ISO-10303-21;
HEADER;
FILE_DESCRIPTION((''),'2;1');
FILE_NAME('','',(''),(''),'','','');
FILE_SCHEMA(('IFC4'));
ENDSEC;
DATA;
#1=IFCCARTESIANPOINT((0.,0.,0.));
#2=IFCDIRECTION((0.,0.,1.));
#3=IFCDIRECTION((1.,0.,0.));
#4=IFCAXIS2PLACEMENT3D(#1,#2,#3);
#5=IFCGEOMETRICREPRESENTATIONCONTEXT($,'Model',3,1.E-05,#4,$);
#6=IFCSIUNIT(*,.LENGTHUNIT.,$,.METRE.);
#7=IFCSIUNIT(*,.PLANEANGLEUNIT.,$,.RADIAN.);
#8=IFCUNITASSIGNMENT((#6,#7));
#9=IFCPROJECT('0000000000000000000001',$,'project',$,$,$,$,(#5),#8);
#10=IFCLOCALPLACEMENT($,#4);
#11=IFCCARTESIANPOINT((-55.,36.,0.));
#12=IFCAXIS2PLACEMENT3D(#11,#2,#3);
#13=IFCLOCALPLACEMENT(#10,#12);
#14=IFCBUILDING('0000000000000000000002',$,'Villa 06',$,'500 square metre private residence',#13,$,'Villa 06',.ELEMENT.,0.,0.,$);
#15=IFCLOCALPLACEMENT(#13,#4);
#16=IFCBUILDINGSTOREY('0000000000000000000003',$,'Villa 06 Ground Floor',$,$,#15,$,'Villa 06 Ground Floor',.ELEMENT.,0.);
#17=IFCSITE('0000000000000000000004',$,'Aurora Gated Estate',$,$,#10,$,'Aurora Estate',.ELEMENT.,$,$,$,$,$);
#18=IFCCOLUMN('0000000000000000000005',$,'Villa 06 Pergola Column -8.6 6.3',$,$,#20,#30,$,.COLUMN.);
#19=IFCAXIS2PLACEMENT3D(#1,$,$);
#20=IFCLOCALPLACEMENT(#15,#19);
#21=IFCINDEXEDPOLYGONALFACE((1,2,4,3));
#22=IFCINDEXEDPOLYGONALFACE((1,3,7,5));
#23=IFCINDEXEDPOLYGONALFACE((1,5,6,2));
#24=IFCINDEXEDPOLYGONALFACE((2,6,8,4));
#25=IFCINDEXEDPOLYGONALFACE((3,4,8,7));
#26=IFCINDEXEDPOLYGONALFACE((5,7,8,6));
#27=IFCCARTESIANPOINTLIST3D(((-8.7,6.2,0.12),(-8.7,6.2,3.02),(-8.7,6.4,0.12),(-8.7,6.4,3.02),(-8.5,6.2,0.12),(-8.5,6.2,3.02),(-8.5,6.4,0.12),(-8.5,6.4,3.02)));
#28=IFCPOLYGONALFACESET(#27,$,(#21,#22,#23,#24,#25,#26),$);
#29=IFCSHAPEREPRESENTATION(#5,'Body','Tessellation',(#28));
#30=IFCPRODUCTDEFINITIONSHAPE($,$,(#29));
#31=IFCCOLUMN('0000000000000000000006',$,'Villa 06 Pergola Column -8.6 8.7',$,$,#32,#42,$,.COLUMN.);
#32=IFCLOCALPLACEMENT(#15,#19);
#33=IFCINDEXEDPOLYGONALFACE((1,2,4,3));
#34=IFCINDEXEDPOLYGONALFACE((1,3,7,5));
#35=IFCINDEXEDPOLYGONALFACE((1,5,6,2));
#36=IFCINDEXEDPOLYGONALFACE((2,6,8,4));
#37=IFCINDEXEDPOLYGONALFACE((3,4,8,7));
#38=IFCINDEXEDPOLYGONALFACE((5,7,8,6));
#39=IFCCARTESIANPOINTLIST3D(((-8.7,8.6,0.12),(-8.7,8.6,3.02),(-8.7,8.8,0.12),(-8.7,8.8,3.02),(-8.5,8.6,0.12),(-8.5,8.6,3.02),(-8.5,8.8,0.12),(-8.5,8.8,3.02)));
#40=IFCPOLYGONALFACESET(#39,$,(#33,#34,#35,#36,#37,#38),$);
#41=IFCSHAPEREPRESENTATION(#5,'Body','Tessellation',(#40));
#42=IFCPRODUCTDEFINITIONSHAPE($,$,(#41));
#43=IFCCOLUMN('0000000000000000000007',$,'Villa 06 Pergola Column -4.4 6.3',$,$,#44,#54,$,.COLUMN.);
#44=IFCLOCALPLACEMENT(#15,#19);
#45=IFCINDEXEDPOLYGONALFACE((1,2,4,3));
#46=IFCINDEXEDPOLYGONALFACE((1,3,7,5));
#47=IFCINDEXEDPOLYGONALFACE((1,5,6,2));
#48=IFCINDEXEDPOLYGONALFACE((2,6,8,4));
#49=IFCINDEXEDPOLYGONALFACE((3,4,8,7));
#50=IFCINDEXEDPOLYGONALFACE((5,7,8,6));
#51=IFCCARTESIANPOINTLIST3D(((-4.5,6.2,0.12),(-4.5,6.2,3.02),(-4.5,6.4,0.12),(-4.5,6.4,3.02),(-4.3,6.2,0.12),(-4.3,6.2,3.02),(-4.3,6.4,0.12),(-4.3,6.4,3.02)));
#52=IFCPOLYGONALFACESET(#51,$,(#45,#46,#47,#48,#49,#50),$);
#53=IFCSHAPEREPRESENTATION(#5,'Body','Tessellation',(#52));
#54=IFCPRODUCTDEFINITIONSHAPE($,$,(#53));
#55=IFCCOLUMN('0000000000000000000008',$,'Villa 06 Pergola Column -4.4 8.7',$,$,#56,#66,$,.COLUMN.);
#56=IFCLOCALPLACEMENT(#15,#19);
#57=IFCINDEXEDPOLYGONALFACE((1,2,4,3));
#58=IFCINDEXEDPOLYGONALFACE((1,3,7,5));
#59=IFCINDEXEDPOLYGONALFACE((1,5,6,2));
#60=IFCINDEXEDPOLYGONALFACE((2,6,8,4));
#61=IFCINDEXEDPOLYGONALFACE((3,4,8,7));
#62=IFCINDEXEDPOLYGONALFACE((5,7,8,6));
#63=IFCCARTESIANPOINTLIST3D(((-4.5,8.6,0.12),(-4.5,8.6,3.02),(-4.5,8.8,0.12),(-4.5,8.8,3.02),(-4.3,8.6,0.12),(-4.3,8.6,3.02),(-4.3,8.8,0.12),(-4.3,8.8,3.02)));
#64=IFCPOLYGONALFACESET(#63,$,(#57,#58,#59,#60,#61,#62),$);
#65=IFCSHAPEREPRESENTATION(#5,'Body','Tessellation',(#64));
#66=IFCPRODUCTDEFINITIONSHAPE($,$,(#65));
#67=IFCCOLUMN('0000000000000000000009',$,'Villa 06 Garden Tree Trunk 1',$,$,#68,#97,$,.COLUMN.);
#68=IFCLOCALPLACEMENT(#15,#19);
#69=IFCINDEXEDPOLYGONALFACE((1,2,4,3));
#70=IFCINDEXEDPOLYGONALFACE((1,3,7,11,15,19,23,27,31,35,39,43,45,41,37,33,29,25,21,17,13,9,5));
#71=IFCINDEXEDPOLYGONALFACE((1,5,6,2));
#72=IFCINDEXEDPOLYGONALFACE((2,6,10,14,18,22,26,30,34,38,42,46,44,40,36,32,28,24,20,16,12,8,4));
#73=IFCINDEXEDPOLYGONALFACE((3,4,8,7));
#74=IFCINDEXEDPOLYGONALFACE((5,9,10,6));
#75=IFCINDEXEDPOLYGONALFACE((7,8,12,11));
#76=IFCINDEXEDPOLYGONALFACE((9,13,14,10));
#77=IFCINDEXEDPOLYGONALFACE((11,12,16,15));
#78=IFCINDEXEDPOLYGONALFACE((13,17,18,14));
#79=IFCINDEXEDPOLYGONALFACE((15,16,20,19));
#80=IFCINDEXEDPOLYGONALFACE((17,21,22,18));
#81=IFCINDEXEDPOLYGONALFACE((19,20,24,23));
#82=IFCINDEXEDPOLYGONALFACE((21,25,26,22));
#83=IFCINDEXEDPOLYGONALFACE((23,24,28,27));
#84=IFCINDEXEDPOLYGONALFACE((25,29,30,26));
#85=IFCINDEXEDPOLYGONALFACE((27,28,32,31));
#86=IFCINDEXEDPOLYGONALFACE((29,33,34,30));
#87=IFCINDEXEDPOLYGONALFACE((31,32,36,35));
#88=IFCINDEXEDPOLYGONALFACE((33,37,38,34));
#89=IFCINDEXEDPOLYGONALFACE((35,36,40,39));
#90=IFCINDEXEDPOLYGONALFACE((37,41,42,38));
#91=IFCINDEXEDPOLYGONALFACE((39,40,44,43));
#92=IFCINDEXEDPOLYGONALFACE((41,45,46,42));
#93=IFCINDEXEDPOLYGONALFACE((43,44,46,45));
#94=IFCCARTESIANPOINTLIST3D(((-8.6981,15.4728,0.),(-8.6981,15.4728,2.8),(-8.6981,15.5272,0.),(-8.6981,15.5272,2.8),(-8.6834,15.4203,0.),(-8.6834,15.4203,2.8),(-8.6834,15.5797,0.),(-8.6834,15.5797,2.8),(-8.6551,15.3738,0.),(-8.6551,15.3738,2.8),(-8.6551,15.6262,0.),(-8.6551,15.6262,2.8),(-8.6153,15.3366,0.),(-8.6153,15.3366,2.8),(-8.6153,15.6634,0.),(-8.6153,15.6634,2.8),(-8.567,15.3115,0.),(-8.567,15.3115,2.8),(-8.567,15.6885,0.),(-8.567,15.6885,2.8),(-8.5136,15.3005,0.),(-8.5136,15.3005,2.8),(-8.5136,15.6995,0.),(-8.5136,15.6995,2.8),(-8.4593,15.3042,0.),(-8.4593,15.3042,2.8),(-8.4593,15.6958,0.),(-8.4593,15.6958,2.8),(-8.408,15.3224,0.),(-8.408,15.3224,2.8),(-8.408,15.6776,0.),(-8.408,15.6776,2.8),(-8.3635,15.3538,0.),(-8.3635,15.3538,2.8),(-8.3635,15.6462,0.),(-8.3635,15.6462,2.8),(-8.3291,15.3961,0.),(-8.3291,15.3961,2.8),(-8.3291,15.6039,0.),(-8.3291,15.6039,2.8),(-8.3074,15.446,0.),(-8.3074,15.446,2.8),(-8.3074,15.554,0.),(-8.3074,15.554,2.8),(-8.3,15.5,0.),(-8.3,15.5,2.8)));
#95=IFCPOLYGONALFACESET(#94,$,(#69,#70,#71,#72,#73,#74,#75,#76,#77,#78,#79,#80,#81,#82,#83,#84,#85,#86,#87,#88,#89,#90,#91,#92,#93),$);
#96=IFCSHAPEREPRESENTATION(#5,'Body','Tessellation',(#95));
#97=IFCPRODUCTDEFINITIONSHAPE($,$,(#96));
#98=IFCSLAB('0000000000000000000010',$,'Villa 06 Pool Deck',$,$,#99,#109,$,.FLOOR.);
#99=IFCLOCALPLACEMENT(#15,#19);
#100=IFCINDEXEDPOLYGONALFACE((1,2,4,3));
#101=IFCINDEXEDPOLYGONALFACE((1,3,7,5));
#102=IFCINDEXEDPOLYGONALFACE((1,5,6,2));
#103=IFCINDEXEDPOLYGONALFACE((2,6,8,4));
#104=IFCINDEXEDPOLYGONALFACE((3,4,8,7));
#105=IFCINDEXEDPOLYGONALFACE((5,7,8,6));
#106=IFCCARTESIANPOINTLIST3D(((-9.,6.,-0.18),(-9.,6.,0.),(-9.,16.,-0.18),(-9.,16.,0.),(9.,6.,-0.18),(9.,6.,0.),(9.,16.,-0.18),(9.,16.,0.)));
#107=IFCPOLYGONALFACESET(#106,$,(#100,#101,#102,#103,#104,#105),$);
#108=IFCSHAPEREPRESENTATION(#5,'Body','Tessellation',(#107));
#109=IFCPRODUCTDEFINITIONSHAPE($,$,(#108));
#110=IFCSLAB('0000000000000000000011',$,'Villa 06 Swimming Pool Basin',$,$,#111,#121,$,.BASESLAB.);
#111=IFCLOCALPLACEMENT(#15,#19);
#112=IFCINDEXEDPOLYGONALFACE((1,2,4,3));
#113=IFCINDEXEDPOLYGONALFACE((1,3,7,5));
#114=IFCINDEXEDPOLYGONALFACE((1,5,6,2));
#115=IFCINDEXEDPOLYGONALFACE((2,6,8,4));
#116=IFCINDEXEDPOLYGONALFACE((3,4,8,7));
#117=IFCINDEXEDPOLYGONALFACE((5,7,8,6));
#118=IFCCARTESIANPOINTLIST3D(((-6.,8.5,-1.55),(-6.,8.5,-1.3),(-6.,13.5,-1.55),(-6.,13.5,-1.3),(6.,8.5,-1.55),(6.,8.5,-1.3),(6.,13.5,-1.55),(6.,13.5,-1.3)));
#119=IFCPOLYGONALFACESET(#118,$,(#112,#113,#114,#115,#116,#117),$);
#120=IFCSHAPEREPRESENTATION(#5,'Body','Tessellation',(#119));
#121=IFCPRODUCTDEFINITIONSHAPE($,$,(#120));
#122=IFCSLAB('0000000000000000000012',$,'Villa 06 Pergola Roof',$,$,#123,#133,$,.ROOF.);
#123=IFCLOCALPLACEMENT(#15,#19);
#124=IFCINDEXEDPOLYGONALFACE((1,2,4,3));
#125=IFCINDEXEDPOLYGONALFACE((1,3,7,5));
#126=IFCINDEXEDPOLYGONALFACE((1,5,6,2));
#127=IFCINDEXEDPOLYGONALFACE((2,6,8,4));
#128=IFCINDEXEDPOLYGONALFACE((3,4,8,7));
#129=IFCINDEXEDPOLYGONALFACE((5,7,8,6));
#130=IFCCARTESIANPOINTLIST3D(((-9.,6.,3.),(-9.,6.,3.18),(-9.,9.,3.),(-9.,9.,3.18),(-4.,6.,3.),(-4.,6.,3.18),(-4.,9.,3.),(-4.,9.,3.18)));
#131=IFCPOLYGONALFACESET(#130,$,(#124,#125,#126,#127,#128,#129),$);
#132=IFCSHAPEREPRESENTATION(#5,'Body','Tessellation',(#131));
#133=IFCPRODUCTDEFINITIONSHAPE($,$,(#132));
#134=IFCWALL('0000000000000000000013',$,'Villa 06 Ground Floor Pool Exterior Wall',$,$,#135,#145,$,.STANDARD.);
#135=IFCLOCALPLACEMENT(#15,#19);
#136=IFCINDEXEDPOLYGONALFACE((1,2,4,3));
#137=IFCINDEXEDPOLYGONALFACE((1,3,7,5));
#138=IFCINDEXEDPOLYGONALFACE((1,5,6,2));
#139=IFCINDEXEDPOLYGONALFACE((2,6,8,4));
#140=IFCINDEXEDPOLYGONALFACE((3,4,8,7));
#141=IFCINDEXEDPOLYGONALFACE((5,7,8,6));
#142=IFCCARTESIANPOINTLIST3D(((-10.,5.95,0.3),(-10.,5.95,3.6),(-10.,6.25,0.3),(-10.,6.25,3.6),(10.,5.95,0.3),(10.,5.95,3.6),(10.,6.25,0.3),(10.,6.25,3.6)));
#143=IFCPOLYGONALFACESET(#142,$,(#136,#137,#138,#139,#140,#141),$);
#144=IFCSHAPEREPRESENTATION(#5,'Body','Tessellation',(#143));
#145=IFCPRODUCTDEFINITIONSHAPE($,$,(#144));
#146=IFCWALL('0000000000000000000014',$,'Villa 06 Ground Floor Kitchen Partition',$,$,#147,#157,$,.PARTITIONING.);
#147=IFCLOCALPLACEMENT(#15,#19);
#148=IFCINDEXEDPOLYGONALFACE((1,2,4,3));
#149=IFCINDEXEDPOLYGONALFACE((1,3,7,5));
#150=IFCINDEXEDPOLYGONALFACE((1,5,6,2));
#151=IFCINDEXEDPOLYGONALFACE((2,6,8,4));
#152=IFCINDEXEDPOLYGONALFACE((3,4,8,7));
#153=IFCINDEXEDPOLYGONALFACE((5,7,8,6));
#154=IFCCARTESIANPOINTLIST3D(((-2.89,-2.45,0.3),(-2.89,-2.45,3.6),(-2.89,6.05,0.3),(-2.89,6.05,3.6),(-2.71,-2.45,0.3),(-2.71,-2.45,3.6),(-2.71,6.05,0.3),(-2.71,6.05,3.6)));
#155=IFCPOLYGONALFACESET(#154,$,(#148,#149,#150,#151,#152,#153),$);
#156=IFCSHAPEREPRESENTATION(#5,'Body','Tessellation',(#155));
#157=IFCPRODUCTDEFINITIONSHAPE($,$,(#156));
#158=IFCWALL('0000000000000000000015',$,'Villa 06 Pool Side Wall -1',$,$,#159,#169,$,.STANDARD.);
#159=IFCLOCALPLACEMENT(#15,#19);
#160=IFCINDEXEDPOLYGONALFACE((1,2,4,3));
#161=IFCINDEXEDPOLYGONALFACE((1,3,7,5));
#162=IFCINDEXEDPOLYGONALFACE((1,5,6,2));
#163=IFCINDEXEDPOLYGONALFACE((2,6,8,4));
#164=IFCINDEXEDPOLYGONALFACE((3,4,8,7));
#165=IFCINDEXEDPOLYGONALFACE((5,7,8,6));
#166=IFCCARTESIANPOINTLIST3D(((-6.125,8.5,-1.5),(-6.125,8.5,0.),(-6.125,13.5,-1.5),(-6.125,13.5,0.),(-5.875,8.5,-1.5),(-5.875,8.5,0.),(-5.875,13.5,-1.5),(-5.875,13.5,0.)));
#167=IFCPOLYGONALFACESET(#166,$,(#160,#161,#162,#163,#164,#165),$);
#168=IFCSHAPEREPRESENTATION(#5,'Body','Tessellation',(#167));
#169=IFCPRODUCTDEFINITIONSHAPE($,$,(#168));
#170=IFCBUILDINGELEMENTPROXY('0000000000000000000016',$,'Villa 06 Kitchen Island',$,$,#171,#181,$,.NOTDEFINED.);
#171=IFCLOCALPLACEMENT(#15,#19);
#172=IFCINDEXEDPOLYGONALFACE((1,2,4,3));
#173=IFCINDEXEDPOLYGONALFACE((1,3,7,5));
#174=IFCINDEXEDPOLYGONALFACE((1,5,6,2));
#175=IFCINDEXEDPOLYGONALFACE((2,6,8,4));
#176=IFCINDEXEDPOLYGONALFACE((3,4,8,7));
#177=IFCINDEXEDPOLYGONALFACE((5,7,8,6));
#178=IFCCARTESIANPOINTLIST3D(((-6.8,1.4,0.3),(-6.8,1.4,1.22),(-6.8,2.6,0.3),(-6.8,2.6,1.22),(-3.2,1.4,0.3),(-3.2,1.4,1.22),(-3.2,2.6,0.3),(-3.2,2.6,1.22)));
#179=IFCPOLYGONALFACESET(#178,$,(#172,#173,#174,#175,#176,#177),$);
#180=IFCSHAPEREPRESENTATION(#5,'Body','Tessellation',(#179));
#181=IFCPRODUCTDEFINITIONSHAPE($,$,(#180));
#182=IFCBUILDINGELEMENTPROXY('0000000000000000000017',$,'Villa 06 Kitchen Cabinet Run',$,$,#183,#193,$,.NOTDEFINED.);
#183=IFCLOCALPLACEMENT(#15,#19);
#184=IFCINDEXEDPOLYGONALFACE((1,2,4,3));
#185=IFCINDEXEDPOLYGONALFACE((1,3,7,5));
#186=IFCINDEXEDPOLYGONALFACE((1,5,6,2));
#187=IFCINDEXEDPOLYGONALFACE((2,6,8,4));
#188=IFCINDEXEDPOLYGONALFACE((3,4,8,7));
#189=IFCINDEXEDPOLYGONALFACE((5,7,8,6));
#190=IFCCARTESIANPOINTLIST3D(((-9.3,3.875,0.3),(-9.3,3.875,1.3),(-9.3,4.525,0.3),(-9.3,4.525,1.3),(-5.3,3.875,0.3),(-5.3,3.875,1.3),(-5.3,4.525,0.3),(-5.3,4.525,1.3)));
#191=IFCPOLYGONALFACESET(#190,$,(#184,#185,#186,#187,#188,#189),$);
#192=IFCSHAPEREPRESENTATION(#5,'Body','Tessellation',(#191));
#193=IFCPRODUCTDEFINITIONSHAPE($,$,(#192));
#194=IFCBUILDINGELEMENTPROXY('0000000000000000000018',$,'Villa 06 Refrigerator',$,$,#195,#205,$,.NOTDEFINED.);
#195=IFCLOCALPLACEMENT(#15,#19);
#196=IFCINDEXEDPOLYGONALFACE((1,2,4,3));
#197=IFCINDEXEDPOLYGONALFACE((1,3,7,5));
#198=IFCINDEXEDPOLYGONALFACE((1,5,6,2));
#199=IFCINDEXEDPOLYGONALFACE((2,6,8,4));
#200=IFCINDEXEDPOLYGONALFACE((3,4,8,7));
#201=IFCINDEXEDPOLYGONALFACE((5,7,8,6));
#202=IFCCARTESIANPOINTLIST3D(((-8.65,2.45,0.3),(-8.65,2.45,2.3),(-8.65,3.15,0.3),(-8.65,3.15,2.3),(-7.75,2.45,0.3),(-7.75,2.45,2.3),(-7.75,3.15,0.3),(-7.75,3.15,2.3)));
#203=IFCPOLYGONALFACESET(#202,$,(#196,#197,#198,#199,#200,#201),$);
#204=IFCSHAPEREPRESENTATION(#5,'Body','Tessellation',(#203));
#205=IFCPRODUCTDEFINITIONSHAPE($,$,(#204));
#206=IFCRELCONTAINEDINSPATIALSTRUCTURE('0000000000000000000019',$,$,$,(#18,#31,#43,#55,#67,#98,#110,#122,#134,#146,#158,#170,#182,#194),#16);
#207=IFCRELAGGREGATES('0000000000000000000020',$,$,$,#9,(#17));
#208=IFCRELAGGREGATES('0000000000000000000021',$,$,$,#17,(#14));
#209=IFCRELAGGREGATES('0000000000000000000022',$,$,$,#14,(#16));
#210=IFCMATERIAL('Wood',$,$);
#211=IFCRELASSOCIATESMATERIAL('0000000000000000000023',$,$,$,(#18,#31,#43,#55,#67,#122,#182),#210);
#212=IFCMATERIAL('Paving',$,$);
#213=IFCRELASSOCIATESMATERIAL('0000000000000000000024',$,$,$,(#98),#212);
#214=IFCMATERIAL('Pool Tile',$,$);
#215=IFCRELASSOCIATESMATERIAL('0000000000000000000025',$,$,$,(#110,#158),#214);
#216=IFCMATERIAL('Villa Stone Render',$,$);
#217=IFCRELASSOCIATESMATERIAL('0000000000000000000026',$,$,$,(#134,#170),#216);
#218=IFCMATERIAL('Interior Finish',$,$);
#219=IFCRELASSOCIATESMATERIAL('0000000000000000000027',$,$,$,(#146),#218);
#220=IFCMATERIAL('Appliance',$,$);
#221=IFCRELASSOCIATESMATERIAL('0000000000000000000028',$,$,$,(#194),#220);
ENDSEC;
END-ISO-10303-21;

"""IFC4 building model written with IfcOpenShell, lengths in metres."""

from ifc_helpers import new_model, si_unit, frame, origin_with_axes, origin_2d_with_axis, place, context, project, spatial, rectangle, circle, extrude, material, element, save


model = new_model("IFC4")

# Units and contexts
model_context = context("Model", 3, precision=1e-05, world=origin_with_axes())
ifc_project = project(units=[si_unit("LENGTHUNIT", "METRE"), si_unit("PLANEANGLEUNIT", "RADIAN")], contexts=[model_context])

# Site, building, storey
site_placement = place(None, origin_with_axes())
site = spatial("IfcSite", under=ifc_project, at=site_placement, Name="Aurora Gated Estate", LongName="Aurora Estate", CompositionType="ELEMENT")
building_placement = place(site_placement, frame((-55.0, 36.0, 0.0), z_axis=(0.0, 0.0, 1.0), x_axis=(1.0, 0.0, 0.0)))
building = spatial("IfcBuilding", under=site, at=building_placement, Name="Villa 06", ObjectType="500 square metre private residence", LongName="Villa 06", CompositionType="ELEMENT", ElevationOfRefHeight=0.0, ElevationOfTerrain=0.0)
storey_placement = place(building_placement, origin_with_axes())
storey = spatial("IfcBuildingStorey", under=building, at=storey_placement, Name="Villa 06 Ground Floor", LongName="Villa 06 Ground Floor", CompositionType="ELEMENT", Elevation=0.0)

# Columns
ifc_material_1 = material(Name="Wood")
for number, where, z_axis, x_axis, name in (
    (1, (-8.6, 6.3, 0.12), (0.0, 0.0, 1.0), (1.0, 0.0, 0.0), "Villa 06 Pergola Column -8.6 6.3"),
    (2, (-8.6, 8.7, 0.12), (0.0, 0.0, 1.0), (1.0, 0.0, 0.0), "Villa 06 Pergola Column -8.6 8.7"),
    (3, (-4.4, 6.3, 0.12), (0.0, 0.0, 1.0), (1.0, 0.0, 0.0), "Villa 06 Pergola Column -4.4 6.3"),
    (4, (-4.4, 8.7, 0.12), (0.0, 0.0, 1.0), (1.0, 0.0, 0.0), "Villa 06 Pergola Column -4.4 8.7"),
):
    element("IfcColumn", number, at=place(storey_placement, frame(where, z_axis=z_axis, x_axis=x_axis)), inside=storey, material=ifc_material_1, Name=name, PredefinedType="COLUMN", context=model_context, shape_type="SweptSolid", body=[
        extrude(rectangle(XDim=0.2, YDim=0.2, at=origin_2d_with_axis()), origin_with_axes(), (0.0, 0.0, 1.0), 2.9),
    ])
column_placement = place(storey_placement, frame((-8.5, 15.5, 0.0), z_axis=(0.0, 0.0, 1.0), x_axis=(1.0, 0.0, 0.0)))
element("IfcColumn", 5, at=column_placement, inside=storey, material=ifc_material_1, Name="Villa 06 Garden Tree Trunk 1", PredefinedType="COLUMN", context=model_context, shape_type="SweptSolid", body=[
    extrude(circle(Radius=0.2, at=origin_2d_with_axis()), origin_with_axes(), (0.0, 0.0, 1.0), 2.8),
])

# Slabs
ifc_material_2 = material(Name="Paving")
slab_1_placement = place(storey_placement, frame((0.0, 11.0, -0.18), z_axis=(0.0, 0.0, 1.0), x_axis=(1.0, 0.0, 0.0)))
element("IfcSlab", 6, at=slab_1_placement, inside=storey, material=ifc_material_2, Name="Villa 06 Pool Deck", PredefinedType="FLOOR", context=model_context, shape_type="SweptSolid", body=[
    extrude(rectangle(XDim=18.0, YDim=10.0, at=origin_2d_with_axis()), origin_with_axes(), (0.0, 0.0, 1.0), 0.18),
])
ifc_material_3 = material(Name="Pool Tile")
slab_2_placement = place(storey_placement, frame((0.0, 11.0, -1.55), z_axis=(0.0, 0.0, 1.0), x_axis=(1.0, 0.0, 0.0)))
element("IfcSlab", 7, at=slab_2_placement, inside=storey, material=ifc_material_3, Name="Villa 06 Swimming Pool Basin", PredefinedType="BASESLAB", context=model_context, shape_type="SweptSolid", body=[
    extrude(rectangle(XDim=12.0, YDim=5.0, at=origin_2d_with_axis()), origin_with_axes(), (0.0, 0.0, 1.0), 0.25),
])
slab_3_placement = place(storey_placement, frame((-6.5, 7.5, 3.0), z_axis=(0.0, 0.0, 1.0), x_axis=(1.0, 0.0, 0.0)))
element("IfcSlab", 8, at=slab_3_placement, inside=storey, material=ifc_material_1, Name="Villa 06 Pergola Roof", PredefinedType="ROOF", context=model_context, shape_type="SweptSolid", body=[
    extrude(rectangle(XDim=5.0, YDim=3.0, at=origin_2d_with_axis()), origin_with_axes(), (0.0, 0.0, 1.0), 0.18),
])

# Walls
ifc_material_4 = material(Name="Villa Stone Render")
wall_1_placement = place(storey_placement, frame((0.0, 6.1, 0.3), z_axis=(0.0, 0.0, 1.0), x_axis=(1.0, 0.0, 0.0)))
element("IfcWall", 9, at=wall_1_placement, inside=storey, material=ifc_material_4, Name="Villa 06 Ground Floor Pool Exterior Wall", PredefinedType="STANDARD", context=model_context, shape_type="SweptSolid", body=[
    extrude(rectangle(XDim=20.0, YDim=0.3, at=origin_2d_with_axis()), origin_with_axes(), (0.0, 0.0, 1.0), 3.3),
])
ifc_material_5 = material(Name="Interior Finish")
wall_2_placement = place(storey_placement, frame((-2.8, 1.8, 0.3), z_axis=(0.0, 0.0, 1.0), x_axis=(1.0, 0.0, 0.0)))
element("IfcWall", 10, at=wall_2_placement, inside=storey, material=ifc_material_5, Name="Villa 06 Ground Floor Kitchen Partition", PredefinedType="PARTITIONING", context=model_context, shape_type="SweptSolid", body=[
    extrude(rectangle(XDim=0.18, YDim=8.5, at=origin_2d_with_axis()), origin_with_axes(), (0.0, 0.0, 1.0), 3.3),
])
wall_3_placement = place(storey_placement, frame((-6.0, 11.0, -1.5), z_axis=(0.0, 0.0, 1.0), x_axis=(1.0, 0.0, 0.0)))
element("IfcWall", 11, at=wall_3_placement, inside=storey, material=ifc_material_3, Name="Villa 06 Pool Side Wall -1", PredefinedType="STANDARD", context=model_context, shape_type="SweptSolid", body=[
    extrude(rectangle(XDim=0.25, YDim=5.0, at=origin_2d_with_axis()), origin_with_axes(), (0.0, 0.0, 1.0), 1.5),
])

# Building element proxies
proxy_1_placement = place(storey_placement, frame((-5.0, 2.0, 0.3), z_axis=(0.0, 0.0, 1.0), x_axis=(1.0, 0.0, 0.0)))
element("IfcBuildingElementProxy", 12, at=proxy_1_placement, inside=storey, material=ifc_material_4, Name="Villa 06 Kitchen Island", PredefinedType="NOTDEFINED", context=model_context, shape_type="SweptSolid", body=[
    extrude(rectangle(XDim=3.6, YDim=1.2, at=origin_2d_with_axis()), origin_with_axes(), (0.0, 0.0, 1.0), 0.92),
])
proxy_2_placement = place(storey_placement, frame((-7.3, 4.2, 0.3), z_axis=(0.0, 0.0, 1.0), x_axis=(1.0, 0.0, 0.0)))
element("IfcBuildingElementProxy", 13, at=proxy_2_placement, inside=storey, material=ifc_material_1, Name="Villa 06 Kitchen Cabinet Run", PredefinedType="NOTDEFINED", context=model_context, shape_type="SweptSolid", body=[
    extrude(rectangle(XDim=4.0, YDim=0.65, at=origin_2d_with_axis()), origin_with_axes(), (0.0, 0.0, 1.0), 1.0),
])
ifc_material_6 = material(Name="Appliance")
proxy_3_placement = place(storey_placement, frame((-8.2, 2.8, 0.3), z_axis=(0.0, 0.0, 1.0), x_axis=(1.0, 0.0, 0.0)))
element("IfcBuildingElementProxy", 14, at=proxy_3_placement, inside=storey, material=ifc_material_6, Name="Villa 06 Refrigerator", PredefinedType="NOTDEFINED", context=model_context, shape_type="SweptSolid", body=[
    extrude(rectangle(XDim=0.9, YDim=0.7, at=origin_2d_with_axis()), origin_with_axes(), (0.0, 0.0, 1.0), 2.0),
])

save(model, "model.ifc")
